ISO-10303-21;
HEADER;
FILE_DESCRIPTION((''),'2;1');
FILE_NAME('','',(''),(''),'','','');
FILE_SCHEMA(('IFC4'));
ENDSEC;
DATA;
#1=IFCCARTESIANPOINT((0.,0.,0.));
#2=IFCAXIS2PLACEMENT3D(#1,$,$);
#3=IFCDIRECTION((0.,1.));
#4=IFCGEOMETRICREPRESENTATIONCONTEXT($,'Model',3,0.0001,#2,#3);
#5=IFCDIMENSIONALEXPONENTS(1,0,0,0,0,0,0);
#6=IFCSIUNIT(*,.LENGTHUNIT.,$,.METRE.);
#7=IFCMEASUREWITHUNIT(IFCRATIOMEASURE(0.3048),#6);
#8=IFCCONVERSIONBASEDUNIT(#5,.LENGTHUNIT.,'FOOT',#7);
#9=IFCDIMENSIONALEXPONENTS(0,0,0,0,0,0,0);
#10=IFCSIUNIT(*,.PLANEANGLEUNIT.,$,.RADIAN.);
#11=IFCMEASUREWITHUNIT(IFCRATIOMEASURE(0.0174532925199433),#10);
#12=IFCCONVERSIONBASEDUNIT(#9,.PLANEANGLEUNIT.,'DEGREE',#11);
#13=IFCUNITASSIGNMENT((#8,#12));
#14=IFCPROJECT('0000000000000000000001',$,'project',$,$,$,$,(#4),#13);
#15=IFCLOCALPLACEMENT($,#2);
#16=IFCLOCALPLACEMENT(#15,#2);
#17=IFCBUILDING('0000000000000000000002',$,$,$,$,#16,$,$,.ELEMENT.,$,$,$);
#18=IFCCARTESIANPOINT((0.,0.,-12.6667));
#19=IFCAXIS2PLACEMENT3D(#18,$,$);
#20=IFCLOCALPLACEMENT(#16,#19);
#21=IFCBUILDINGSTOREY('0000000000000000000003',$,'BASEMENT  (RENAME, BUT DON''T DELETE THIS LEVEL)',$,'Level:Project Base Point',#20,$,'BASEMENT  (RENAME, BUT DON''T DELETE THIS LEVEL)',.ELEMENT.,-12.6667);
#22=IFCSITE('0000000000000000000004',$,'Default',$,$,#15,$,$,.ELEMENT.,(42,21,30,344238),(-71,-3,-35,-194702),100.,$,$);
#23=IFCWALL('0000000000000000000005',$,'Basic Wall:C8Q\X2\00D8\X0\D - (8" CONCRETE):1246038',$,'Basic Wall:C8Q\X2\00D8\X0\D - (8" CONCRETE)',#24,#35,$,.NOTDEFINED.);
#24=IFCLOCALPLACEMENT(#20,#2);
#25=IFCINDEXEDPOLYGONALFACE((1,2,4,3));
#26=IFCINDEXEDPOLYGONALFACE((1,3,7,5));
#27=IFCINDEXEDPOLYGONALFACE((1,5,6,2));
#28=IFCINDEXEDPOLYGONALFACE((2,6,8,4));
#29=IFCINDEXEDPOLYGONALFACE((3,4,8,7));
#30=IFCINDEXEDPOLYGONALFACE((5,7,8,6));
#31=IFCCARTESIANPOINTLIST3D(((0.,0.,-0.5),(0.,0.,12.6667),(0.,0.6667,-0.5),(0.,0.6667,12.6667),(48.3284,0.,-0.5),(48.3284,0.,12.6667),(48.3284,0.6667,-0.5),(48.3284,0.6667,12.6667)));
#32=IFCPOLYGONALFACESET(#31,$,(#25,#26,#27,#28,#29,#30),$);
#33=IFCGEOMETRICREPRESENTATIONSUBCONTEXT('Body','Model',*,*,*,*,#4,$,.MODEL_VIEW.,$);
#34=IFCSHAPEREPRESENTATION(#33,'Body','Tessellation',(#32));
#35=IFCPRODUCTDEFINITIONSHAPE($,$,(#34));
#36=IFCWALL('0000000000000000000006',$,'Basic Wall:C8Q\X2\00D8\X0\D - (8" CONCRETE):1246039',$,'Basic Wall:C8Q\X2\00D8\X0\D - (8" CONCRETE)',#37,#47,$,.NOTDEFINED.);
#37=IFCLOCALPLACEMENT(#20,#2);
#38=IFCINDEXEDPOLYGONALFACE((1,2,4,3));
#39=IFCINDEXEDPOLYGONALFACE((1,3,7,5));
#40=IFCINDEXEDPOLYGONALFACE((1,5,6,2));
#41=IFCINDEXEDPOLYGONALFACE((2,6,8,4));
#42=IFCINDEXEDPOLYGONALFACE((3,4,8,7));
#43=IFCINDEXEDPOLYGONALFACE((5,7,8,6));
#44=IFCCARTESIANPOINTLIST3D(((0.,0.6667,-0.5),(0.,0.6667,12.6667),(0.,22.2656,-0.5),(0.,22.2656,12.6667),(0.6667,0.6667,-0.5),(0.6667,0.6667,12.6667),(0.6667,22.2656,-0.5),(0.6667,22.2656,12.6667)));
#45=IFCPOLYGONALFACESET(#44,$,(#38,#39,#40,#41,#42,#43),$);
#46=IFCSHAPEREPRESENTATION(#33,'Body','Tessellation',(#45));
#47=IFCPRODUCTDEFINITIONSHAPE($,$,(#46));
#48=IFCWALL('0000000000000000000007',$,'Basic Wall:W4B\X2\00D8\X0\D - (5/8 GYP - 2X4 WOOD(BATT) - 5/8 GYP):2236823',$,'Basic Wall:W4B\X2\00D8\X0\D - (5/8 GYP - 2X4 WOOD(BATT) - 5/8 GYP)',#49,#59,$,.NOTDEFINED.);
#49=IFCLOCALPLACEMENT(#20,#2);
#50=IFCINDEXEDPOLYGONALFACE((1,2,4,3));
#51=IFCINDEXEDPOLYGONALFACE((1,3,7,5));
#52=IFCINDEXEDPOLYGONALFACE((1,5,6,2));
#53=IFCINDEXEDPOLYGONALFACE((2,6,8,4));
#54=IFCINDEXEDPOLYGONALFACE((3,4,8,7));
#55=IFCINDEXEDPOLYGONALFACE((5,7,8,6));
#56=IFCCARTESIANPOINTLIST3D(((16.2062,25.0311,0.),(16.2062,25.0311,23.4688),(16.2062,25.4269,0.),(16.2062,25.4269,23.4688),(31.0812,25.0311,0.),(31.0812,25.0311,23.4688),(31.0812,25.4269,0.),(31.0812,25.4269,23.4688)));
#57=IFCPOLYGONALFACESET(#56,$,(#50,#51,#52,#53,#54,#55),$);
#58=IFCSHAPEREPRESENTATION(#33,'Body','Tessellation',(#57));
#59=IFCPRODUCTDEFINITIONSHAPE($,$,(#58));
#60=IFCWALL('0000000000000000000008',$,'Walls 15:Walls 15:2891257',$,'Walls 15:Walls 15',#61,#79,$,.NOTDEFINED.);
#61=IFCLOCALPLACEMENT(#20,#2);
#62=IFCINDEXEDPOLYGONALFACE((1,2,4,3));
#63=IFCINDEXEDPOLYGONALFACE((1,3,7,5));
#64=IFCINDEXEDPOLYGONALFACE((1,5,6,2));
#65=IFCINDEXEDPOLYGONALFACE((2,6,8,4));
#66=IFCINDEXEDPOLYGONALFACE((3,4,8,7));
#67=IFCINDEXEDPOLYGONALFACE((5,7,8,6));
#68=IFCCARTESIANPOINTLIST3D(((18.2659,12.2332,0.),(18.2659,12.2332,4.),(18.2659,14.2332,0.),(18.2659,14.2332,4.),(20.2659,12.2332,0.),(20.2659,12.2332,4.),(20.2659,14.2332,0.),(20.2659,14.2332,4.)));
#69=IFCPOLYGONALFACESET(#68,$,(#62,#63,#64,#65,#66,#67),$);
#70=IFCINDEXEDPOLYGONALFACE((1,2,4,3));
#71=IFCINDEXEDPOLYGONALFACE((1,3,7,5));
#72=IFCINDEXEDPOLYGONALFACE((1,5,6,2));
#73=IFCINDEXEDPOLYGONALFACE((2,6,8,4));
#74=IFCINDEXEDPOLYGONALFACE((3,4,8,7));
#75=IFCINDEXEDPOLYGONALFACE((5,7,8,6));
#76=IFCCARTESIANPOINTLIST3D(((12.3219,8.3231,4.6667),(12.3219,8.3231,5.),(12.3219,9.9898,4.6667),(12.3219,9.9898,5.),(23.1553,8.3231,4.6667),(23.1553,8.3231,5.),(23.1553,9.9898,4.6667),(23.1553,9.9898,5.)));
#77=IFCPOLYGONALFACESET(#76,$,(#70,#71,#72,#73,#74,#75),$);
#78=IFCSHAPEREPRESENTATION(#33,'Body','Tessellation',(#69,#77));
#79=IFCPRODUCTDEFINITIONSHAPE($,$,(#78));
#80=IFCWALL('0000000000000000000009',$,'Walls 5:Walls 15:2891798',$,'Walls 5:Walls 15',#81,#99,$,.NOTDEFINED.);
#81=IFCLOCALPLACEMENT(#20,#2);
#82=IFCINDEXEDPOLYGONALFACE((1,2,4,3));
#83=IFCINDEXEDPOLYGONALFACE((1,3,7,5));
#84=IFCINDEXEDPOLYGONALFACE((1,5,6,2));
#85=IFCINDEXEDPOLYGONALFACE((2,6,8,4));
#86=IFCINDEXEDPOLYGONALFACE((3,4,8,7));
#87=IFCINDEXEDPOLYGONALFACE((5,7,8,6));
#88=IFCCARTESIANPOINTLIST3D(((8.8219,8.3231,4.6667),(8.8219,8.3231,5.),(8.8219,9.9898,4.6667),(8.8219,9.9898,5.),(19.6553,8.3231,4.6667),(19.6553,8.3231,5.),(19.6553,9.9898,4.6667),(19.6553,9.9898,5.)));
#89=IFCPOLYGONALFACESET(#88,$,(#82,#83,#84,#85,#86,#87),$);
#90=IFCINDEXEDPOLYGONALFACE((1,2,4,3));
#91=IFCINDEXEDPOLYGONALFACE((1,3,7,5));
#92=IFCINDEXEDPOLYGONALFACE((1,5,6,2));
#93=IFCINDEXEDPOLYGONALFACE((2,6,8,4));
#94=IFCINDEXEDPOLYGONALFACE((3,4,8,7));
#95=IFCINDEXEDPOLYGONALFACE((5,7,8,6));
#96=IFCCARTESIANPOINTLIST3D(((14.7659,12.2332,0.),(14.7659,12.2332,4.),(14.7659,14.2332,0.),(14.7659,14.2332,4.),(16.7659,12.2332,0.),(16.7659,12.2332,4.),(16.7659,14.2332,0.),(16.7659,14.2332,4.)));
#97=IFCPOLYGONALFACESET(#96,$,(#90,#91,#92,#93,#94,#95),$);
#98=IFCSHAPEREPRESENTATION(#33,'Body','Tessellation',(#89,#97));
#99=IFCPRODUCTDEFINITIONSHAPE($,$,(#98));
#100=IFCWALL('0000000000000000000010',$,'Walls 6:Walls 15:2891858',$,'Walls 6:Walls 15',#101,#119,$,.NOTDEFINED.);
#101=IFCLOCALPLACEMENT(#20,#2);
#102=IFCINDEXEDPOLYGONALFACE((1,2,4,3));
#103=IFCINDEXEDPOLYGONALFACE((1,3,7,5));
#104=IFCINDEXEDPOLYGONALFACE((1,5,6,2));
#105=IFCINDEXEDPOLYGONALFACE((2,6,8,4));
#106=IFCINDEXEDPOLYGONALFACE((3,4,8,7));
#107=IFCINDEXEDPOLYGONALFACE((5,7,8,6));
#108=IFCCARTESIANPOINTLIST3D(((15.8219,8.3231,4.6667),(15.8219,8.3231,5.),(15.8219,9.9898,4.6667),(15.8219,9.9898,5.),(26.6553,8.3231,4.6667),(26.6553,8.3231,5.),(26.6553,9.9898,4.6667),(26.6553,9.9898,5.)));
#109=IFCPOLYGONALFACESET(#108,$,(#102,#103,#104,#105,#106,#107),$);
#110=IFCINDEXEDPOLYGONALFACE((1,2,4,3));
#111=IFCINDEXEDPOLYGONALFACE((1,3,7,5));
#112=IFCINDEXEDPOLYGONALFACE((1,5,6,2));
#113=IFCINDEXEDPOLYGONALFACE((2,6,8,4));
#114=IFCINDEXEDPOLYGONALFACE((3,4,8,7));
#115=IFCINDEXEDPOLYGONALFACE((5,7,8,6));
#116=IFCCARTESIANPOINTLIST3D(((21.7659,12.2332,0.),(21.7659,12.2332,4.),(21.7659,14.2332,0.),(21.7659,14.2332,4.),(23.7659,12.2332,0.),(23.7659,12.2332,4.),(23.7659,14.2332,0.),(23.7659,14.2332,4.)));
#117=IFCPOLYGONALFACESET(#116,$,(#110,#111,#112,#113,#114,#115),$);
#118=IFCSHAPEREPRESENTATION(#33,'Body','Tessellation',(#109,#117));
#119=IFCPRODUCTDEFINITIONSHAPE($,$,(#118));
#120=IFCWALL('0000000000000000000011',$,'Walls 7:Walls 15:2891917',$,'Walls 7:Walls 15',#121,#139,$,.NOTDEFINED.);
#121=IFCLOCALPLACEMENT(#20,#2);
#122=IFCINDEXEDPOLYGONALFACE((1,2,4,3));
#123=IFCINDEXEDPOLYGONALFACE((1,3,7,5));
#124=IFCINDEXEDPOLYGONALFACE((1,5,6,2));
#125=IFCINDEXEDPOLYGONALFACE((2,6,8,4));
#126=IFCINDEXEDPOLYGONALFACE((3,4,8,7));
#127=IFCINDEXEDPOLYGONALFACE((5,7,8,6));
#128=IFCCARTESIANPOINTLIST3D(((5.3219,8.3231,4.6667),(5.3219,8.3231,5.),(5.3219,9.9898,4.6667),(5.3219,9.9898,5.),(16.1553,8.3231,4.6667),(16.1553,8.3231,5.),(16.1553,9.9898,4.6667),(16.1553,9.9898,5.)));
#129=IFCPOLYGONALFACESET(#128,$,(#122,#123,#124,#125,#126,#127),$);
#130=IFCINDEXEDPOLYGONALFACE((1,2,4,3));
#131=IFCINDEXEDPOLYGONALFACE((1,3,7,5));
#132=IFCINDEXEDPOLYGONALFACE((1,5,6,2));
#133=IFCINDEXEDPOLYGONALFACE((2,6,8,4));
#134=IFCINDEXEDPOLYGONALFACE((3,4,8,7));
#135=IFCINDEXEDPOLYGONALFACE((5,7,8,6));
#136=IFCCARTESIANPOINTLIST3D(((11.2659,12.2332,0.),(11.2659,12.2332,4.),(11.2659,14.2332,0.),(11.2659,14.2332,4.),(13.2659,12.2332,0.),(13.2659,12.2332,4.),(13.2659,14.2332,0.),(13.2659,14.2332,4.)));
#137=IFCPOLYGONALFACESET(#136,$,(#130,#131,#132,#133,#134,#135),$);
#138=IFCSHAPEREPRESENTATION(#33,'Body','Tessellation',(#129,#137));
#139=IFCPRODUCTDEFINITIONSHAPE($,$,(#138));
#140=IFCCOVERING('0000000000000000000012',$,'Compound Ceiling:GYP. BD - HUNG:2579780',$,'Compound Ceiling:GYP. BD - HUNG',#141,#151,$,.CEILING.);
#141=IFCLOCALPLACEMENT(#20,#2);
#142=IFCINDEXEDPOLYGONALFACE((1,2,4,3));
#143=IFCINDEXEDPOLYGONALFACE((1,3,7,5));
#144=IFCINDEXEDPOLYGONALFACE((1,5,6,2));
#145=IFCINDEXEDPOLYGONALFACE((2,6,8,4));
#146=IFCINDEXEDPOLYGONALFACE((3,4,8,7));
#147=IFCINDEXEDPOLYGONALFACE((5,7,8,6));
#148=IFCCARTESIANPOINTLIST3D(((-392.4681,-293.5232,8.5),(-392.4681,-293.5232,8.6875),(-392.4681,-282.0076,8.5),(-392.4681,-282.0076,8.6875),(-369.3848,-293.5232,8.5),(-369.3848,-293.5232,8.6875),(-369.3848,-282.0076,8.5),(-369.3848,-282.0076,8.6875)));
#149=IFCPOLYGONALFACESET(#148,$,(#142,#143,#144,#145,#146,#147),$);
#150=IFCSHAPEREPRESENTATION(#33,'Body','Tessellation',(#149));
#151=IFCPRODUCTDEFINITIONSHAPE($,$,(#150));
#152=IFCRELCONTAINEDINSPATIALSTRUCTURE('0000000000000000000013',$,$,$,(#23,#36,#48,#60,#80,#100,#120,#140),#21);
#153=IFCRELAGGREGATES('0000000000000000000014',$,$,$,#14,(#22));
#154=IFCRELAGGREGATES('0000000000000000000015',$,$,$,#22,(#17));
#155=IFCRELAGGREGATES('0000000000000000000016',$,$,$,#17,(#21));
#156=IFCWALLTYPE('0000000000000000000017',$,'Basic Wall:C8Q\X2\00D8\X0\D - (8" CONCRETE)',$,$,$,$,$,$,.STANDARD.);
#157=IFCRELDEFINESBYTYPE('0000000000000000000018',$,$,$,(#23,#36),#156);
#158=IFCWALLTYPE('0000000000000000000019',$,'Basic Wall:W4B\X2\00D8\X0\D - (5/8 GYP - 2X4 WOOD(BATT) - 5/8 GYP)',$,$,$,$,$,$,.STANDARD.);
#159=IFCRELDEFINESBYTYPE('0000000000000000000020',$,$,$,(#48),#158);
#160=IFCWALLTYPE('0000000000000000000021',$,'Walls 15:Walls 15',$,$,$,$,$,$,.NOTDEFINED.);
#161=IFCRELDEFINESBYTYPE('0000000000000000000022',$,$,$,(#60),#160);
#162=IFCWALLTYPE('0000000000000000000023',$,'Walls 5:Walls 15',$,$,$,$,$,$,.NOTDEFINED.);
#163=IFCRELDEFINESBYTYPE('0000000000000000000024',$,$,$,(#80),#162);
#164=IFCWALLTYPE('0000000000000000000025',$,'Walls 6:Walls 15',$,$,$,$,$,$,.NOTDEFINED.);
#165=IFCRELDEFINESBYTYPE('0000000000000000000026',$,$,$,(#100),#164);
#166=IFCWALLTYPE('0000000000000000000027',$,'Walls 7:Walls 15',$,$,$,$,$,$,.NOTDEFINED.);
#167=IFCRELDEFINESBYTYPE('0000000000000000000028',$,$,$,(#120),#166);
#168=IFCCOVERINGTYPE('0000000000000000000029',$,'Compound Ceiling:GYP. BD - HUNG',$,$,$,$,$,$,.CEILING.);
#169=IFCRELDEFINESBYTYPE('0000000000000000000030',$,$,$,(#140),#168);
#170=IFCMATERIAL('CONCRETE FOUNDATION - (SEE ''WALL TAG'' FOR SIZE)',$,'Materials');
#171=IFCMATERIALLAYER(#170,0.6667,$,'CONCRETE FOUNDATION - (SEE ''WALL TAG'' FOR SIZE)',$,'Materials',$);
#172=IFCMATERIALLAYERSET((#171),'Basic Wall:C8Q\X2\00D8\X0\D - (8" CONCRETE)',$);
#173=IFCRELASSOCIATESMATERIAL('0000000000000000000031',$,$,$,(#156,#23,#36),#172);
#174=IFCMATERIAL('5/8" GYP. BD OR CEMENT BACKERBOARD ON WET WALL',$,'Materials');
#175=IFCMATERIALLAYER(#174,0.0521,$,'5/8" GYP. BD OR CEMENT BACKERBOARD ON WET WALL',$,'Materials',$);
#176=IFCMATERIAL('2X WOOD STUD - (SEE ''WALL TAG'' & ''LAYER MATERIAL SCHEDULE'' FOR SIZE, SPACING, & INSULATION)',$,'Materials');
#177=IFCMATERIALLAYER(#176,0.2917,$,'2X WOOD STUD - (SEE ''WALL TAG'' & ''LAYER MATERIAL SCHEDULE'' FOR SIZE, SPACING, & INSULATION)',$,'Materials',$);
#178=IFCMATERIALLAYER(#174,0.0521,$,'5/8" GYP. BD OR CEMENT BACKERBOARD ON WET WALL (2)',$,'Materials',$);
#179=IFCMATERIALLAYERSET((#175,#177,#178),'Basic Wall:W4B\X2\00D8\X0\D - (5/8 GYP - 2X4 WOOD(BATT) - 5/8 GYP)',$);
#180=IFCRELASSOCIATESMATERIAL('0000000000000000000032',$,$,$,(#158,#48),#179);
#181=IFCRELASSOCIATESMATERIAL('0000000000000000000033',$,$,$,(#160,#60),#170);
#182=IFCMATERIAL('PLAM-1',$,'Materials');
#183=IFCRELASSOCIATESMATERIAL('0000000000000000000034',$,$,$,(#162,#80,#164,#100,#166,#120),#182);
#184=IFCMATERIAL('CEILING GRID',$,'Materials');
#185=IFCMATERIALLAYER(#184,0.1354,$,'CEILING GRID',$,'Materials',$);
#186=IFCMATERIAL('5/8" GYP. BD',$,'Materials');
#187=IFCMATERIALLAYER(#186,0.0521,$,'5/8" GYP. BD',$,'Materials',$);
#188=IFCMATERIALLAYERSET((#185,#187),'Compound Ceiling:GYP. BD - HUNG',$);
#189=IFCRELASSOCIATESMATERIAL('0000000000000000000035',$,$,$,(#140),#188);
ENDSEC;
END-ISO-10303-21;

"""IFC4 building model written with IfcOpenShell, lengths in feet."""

from ifc_helpers import new_model, entity, si_unit, converted_unit, direction, frame, frame_2d, origin, origin_2d_with_axis, place, context, subcontext, project, spatial, rectangle, extrude, material, layer, layer_set, layer_usage, type_object, element, save


model = new_model("IFC4")

# Units and contexts
model_context = context("Model", 3, precision=0.0001, world=origin(), true_north=direction((0.0, 1.0)))
body_context = subcontext(model_context, "Body", "Model", "MODEL_VIEW")
ifc_project = project(units=[converted_unit("LENGTHUNIT", "FOOT", entity("IfcRatioMeasure", 0.3048), si_unit("LENGTHUNIT", "METRE"), dimensions=[1, 0, 0, 0, 0, 0, 0]), converted_unit("PLANEANGLEUNIT", "DEGREE", entity("IfcRatioMeasure", 0.0174532925199433), si_unit("PLANEANGLEUNIT", "RADIAN"), dimensions=[0, 0, 0, 0, 0, 0, 0])], contexts=[model_context])

# Site, building, storey
site_placement = place(None, origin())
site = spatial("IfcSite", under=ifc_project, at=site_placement, Name="Default", CompositionType="ELEMENT", RefLatitude=(42, 21, 30, 344238), RefLongitude=(-71, -3, -35, -194702), RefElevation=100.0)
building_placement = place(site_placement, origin())
building = spatial("IfcBuilding", under=site, at=building_placement, CompositionType="ELEMENT")
storey_placement = place(building_placement, frame((0.0, 0.0, -12.6667)))
storey = spatial("IfcBuildingStorey", under=building, at=storey_placement, Name="BASEMENT  (RENAME, BUT DON'T DELETE THIS LEVEL)", ObjectType="Level:Project Base Point", LongName="BASEMENT  (RENAME, BUT DON'T DELETE THIS LEVEL)", CompositionType="ELEMENT", Elevation=-12.6667)

# Shared definitions
ifc_material_1 = material(Name="5/8\" GYP. BD", Category="Materials")

# Walls
ifc_material_2 = material(Name="CONCRETE FOUNDATION - (SEE 'WALL TAG' FOR SIZE)", Category="Materials")
ifc_layer_1 = layer(ifc_material_2, 0.6667, Name="CONCRETE FOUNDATION - (SEE 'WALL TAG' FOR SIZE)", Category="Materials")
ifc_layer_set_1 = layer_set([ifc_layer_1], Name="Basic Wall:C8QØD - (8\" CONCRETE)")
ifc_layer_usage_1 = layer_usage(ifc_layer_set_1, "AXIS2", "POSITIVE", -0.3333)
wall_type_1 = type_object("IfcWallType", Name="Basic Wall:C8QØD - (8\" CONCRETE)", PredefinedType="STANDARD", material=ifc_layer_set_1)
wall_1_placement = place(storey_placement, frame((0.0, 0.3333, -0.5)))
element("IfcWall", 1, at=wall_1_placement, inside=storey, type_object=wall_type_1, material=ifc_layer_usage_1, Name="Basic Wall:C8QØD - (8\" CONCRETE):1246038", ObjectType="Basic Wall:C8QØD - (8\" CONCRETE)", PredefinedType="NOTDEFINED", context=body_context, shape_type="SweptSolid", body=[
    extrude(rectangle(XDim=48.3284, YDim=0.6667, at=frame_2d((24.1642, 0.0), x_axis=(-1.0, 0.0))), origin(), (0.0, 0.0, 1.0), 13.1667),
])
ifc_layer_usage_2 = layer_usage(ifc_layer_set_1, "AXIS2", "POSITIVE", -0.3333)
wall_2_placement = place(storey_placement, frame((0.3333, 22.2656, -0.5), z_axis=(0.0, 0.0, 1.0), x_axis=(0.0, -1.0, 0.0)))
element("IfcWall", 2, at=wall_2_placement, inside=storey, type_object=wall_type_1, material=ifc_layer_usage_2, Name="Basic Wall:C8QØD - (8\" CONCRETE):1246039", ObjectType="Basic Wall:C8QØD - (8\" CONCRETE)", PredefinedType="NOTDEFINED", context=body_context, shape_type="SweptSolid", body=[
    extrude(rectangle(XDim=21.599, YDim=0.6667, at=frame_2d((10.7995, 0.0), x_axis=(-1.0, 0.0))), origin(), (0.0, 0.0, 1.0), 13.1667),
])
ifc_material_3 = material(Name="5/8\" GYP. BD OR CEMENT BACKERBOARD ON WET WALL", Category="Materials")
ifc_layer_2 = layer(ifc_material_3, 0.0521, Name="5/8\" GYP. BD OR CEMENT BACKERBOARD ON WET WALL", Category="Materials")
ifc_material_4 = material(Name="2X WOOD STUD - (SEE 'WALL TAG' & 'LAYER MATERIAL SCHEDULE' FOR SIZE, SPACING, & INSULATION)", Category="Materials")
ifc_layer_3 = layer(ifc_material_4, 0.2917, Name="2X WOOD STUD - (SEE 'WALL TAG' & 'LAYER MATERIAL SCHEDULE' FOR SIZE, SPACING, & INSULATION)", Category="Materials")
ifc_layer_4 = layer(ifc_material_3, 0.0521, Name="5/8\" GYP. BD OR CEMENT BACKERBOARD ON WET WALL (2)", Category="Materials")
ifc_layer_set_2 = layer_set([ifc_layer_2, ifc_layer_3, ifc_layer_4], Name="Basic Wall:W4BØD - (5/8 GYP - 2X4 WOOD(BATT) - 5/8 GYP)")
ifc_layer_usage_3 = layer_usage(ifc_layer_set_2, "AXIS2", "NEGATIVE", 0.1979)
wall_type_2 = type_object("IfcWallType", Name="Basic Wall:W4BØD - (5/8 GYP - 2X4 WOOD(BATT) - 5/8 GYP)", PredefinedType="STANDARD", material=ifc_layer_set_2)
wall_3_placement = place(storey_placement, frame((16.2062, 25.229, 0.0)))
element("IfcWall", 3, at=wall_3_placement, inside=storey, type_object=wall_type_2, material=ifc_layer_usage_3, Name="Basic Wall:W4BØD - (5/8 GYP - 2X4 WOOD(BATT) - 5/8 GYP):2236823", ObjectType="Basic Wall:W4BØD - (5/8 GYP - 2X4 WOOD(BATT) - 5/8 GYP)", PredefinedType="NOTDEFINED", context=body_context, shape_type="SweptSolid", body=[
    extrude(rectangle(XDim=14.875, YDim=0.3958, at=frame_2d((7.4375, 0.0), x_axis=(-1.0, 0.0))), origin(), (0.0, 0.0, 1.0), 23.4688),
])
wall_type_3 = type_object("IfcWallType", Name="Walls 15:Walls 15", PredefinedType="NOTDEFINED", material=ifc_material_2)
wall_4_placement = place(storey_placement, frame((12.3219, 8.3231, 0.0)))
element("IfcWall", 4, at=wall_4_placement, inside=storey, type_object=wall_type_3, material=ifc_material_2, Name="Walls 15:Walls 15:2891257", ObjectType="Walls 15:Walls 15", PredefinedType="NOTDEFINED", context=body_context, shape_type="SweptSolid", body=[
    extrude(rectangle(XDim=2.0, YDim=2.0, at=origin_2d_with_axis()), frame((6.944, 4.9101, 0.0), z_axis=(0.0, 0.0, 1.0), x_axis=(-1.0, 0.0, 0.0)), (0.0, 0.0, 1.0), 4.0),
    extrude(rectangle(XDim=10.8333, YDim=1.6667, at=frame_2d((0.0, 0.0), x_axis=(1.0, 0.0))), frame((5.4167, 0.8333, 4.6667), z_axis=(0.0, 0.0, 1.0), x_axis=(-1.0, 0.0, 0.0)), (0.0, 0.0, 1.0), 0.3333),
])
ifc_material_5 = material(Name="PLAM-1", Category="Materials")
wall_type_4 = type_object("IfcWallType", Name="Walls 5:Walls 15", PredefinedType="NOTDEFINED", material=ifc_material_5)
wall_5_placement = place(storey_placement, frame((8.8219, 8.3231, 0.0)))
element("IfcWall", 5, at=wall_5_placement, inside=storey, type_object=wall_type_4, material=ifc_material_5, Name="Walls 5:Walls 15:2891798", ObjectType="Walls 5:Walls 15", PredefinedType="NOTDEFINED", context=body_context, shape_type="SweptSolid", body=[
    extrude(rectangle(XDim=10.8333, YDim=1.6667, at=frame_2d((0.0, 0.0), x_axis=(1.0, 0.0))), frame((5.4167, 0.8333, 4.6667), z_axis=(0.0, 0.0, 1.0), x_axis=(-1.0, 0.0, 0.0)), (0.0, 0.0, 1.0), 0.3333),
    extrude(rectangle(XDim=2.0, YDim=2.0, at=origin_2d_with_axis()), frame((6.944, 4.9101, 0.0), z_axis=(0.0, 0.0, 1.0), x_axis=(-1.0, 0.0, 0.0)), (0.0, 0.0, 1.0), 4.0),
])
wall_type_5 = type_object("IfcWallType", Name="Walls 6:Walls 15", PredefinedType="NOTDEFINED", material=ifc_material_5)
wall_6_placement = place(storey_placement, frame((15.8219, 8.3231, 0.0)))
element("IfcWall", 6, at=wall_6_placement, inside=storey, type_object=wall_type_5, material=ifc_material_5, Name="Walls 6:Walls 15:2891858", ObjectType="Walls 6:Walls 15", PredefinedType="NOTDEFINED", context=body_context, shape_type="SweptSolid", body=[
    extrude(rectangle(XDim=10.8333, YDim=1.6667, at=frame_2d((0.0, 0.0), x_axis=(1.0, 0.0))), frame((5.4167, 0.8333, 4.6667), z_axis=(0.0, 0.0, 1.0), x_axis=(-1.0, 0.0, 0.0)), (0.0, 0.0, 1.0), 0.3333),
    extrude(rectangle(XDim=2.0, YDim=2.0, at=origin_2d_with_axis()), frame((6.944, 4.9101, 0.0), z_axis=(0.0, 0.0, 1.0), x_axis=(-1.0, 0.0, 0.0)), (0.0, 0.0, 1.0), 4.0),
])
wall_type_6 = type_object("IfcWallType", Name="Walls 7:Walls 15", PredefinedType="NOTDEFINED", material=ifc_material_5)
wall_7_placement = place(storey_placement, frame((5.3219, 8.3231, 0.0)))
element("IfcWall", 7, at=wall_7_placement, inside=storey, type_object=wall_type_6, material=ifc_material_5, Name="Walls 7:Walls 15:2891917", ObjectType="Walls 7:Walls 15", PredefinedType="NOTDEFINED", context=body_context, shape_type="SweptSolid", body=[
    extrude(rectangle(XDim=10.8333, YDim=1.6667, at=frame_2d((0.0, 0.0), x_axis=(1.0, 0.0))), frame((5.4167, 0.8333, 4.6667), z_axis=(0.0, 0.0, 1.0), x_axis=(-1.0, 0.0, 0.0)), (0.0, 0.0, 1.0), 0.3333),
    extrude(rectangle(XDim=2.0, YDim=2.0, at=origin_2d_with_axis()), frame((6.944, 4.9101, 0.0), z_axis=(0.0, 0.0, 1.0), x_axis=(-1.0, 0.0, 0.0)), (0.0, 0.0, 1.0), 4.0),
])

# Covering
ifc_material_6 = material(Name="CEILING GRID", Category="Materials")
ifc_layer_5 = layer(ifc_material_6, 0.1354, Name="CEILING GRID", Category="Materials")
ifc_layer_6 = layer(ifc_material_1, 0.0521, Name="5/8\" GYP. BD", Category="Materials")
ifc_layer_set_3 = layer_set([ifc_layer_5, ifc_layer_6], Name="Compound Ceiling:GYP. BD - HUNG")
ifc_layer_usage_4 = layer_usage(ifc_layer_set_3, "AXIS3", "POSITIVE", 0.0)
covering_type_1 = type_object("IfcCoveringType", Name="Compound Ceiling:GYP. BD - HUNG", PredefinedType="CEILING")
covering_1_placement = place(storey_placement, frame((-392.4681, -293.5232, 8.5)))
element("IfcCovering", 8, at=covering_1_placement, inside=storey, type_object=covering_type_1, material=ifc_layer_usage_4, Name="Compound Ceiling:GYP. BD - HUNG:2579780", ObjectType="Compound Ceiling:GYP. BD - HUNG", PredefinedType="CEILING", context=body_context, shape_type="SweptSolid", body=[
    extrude(rectangle(XDim=23.0833, YDim=11.5156, at=frame_2d((0.0, 0.0), x_axis=(1.0, 0.0))), frame((11.5417, 5.7578, 0.0), z_axis=(0.0, 0.0, 1.0), x_axis=(-1.0, 0.0, 0.0)), (0.0, 0.0, 1.0), 0.1875),
])

save(model, "model.ifc")
